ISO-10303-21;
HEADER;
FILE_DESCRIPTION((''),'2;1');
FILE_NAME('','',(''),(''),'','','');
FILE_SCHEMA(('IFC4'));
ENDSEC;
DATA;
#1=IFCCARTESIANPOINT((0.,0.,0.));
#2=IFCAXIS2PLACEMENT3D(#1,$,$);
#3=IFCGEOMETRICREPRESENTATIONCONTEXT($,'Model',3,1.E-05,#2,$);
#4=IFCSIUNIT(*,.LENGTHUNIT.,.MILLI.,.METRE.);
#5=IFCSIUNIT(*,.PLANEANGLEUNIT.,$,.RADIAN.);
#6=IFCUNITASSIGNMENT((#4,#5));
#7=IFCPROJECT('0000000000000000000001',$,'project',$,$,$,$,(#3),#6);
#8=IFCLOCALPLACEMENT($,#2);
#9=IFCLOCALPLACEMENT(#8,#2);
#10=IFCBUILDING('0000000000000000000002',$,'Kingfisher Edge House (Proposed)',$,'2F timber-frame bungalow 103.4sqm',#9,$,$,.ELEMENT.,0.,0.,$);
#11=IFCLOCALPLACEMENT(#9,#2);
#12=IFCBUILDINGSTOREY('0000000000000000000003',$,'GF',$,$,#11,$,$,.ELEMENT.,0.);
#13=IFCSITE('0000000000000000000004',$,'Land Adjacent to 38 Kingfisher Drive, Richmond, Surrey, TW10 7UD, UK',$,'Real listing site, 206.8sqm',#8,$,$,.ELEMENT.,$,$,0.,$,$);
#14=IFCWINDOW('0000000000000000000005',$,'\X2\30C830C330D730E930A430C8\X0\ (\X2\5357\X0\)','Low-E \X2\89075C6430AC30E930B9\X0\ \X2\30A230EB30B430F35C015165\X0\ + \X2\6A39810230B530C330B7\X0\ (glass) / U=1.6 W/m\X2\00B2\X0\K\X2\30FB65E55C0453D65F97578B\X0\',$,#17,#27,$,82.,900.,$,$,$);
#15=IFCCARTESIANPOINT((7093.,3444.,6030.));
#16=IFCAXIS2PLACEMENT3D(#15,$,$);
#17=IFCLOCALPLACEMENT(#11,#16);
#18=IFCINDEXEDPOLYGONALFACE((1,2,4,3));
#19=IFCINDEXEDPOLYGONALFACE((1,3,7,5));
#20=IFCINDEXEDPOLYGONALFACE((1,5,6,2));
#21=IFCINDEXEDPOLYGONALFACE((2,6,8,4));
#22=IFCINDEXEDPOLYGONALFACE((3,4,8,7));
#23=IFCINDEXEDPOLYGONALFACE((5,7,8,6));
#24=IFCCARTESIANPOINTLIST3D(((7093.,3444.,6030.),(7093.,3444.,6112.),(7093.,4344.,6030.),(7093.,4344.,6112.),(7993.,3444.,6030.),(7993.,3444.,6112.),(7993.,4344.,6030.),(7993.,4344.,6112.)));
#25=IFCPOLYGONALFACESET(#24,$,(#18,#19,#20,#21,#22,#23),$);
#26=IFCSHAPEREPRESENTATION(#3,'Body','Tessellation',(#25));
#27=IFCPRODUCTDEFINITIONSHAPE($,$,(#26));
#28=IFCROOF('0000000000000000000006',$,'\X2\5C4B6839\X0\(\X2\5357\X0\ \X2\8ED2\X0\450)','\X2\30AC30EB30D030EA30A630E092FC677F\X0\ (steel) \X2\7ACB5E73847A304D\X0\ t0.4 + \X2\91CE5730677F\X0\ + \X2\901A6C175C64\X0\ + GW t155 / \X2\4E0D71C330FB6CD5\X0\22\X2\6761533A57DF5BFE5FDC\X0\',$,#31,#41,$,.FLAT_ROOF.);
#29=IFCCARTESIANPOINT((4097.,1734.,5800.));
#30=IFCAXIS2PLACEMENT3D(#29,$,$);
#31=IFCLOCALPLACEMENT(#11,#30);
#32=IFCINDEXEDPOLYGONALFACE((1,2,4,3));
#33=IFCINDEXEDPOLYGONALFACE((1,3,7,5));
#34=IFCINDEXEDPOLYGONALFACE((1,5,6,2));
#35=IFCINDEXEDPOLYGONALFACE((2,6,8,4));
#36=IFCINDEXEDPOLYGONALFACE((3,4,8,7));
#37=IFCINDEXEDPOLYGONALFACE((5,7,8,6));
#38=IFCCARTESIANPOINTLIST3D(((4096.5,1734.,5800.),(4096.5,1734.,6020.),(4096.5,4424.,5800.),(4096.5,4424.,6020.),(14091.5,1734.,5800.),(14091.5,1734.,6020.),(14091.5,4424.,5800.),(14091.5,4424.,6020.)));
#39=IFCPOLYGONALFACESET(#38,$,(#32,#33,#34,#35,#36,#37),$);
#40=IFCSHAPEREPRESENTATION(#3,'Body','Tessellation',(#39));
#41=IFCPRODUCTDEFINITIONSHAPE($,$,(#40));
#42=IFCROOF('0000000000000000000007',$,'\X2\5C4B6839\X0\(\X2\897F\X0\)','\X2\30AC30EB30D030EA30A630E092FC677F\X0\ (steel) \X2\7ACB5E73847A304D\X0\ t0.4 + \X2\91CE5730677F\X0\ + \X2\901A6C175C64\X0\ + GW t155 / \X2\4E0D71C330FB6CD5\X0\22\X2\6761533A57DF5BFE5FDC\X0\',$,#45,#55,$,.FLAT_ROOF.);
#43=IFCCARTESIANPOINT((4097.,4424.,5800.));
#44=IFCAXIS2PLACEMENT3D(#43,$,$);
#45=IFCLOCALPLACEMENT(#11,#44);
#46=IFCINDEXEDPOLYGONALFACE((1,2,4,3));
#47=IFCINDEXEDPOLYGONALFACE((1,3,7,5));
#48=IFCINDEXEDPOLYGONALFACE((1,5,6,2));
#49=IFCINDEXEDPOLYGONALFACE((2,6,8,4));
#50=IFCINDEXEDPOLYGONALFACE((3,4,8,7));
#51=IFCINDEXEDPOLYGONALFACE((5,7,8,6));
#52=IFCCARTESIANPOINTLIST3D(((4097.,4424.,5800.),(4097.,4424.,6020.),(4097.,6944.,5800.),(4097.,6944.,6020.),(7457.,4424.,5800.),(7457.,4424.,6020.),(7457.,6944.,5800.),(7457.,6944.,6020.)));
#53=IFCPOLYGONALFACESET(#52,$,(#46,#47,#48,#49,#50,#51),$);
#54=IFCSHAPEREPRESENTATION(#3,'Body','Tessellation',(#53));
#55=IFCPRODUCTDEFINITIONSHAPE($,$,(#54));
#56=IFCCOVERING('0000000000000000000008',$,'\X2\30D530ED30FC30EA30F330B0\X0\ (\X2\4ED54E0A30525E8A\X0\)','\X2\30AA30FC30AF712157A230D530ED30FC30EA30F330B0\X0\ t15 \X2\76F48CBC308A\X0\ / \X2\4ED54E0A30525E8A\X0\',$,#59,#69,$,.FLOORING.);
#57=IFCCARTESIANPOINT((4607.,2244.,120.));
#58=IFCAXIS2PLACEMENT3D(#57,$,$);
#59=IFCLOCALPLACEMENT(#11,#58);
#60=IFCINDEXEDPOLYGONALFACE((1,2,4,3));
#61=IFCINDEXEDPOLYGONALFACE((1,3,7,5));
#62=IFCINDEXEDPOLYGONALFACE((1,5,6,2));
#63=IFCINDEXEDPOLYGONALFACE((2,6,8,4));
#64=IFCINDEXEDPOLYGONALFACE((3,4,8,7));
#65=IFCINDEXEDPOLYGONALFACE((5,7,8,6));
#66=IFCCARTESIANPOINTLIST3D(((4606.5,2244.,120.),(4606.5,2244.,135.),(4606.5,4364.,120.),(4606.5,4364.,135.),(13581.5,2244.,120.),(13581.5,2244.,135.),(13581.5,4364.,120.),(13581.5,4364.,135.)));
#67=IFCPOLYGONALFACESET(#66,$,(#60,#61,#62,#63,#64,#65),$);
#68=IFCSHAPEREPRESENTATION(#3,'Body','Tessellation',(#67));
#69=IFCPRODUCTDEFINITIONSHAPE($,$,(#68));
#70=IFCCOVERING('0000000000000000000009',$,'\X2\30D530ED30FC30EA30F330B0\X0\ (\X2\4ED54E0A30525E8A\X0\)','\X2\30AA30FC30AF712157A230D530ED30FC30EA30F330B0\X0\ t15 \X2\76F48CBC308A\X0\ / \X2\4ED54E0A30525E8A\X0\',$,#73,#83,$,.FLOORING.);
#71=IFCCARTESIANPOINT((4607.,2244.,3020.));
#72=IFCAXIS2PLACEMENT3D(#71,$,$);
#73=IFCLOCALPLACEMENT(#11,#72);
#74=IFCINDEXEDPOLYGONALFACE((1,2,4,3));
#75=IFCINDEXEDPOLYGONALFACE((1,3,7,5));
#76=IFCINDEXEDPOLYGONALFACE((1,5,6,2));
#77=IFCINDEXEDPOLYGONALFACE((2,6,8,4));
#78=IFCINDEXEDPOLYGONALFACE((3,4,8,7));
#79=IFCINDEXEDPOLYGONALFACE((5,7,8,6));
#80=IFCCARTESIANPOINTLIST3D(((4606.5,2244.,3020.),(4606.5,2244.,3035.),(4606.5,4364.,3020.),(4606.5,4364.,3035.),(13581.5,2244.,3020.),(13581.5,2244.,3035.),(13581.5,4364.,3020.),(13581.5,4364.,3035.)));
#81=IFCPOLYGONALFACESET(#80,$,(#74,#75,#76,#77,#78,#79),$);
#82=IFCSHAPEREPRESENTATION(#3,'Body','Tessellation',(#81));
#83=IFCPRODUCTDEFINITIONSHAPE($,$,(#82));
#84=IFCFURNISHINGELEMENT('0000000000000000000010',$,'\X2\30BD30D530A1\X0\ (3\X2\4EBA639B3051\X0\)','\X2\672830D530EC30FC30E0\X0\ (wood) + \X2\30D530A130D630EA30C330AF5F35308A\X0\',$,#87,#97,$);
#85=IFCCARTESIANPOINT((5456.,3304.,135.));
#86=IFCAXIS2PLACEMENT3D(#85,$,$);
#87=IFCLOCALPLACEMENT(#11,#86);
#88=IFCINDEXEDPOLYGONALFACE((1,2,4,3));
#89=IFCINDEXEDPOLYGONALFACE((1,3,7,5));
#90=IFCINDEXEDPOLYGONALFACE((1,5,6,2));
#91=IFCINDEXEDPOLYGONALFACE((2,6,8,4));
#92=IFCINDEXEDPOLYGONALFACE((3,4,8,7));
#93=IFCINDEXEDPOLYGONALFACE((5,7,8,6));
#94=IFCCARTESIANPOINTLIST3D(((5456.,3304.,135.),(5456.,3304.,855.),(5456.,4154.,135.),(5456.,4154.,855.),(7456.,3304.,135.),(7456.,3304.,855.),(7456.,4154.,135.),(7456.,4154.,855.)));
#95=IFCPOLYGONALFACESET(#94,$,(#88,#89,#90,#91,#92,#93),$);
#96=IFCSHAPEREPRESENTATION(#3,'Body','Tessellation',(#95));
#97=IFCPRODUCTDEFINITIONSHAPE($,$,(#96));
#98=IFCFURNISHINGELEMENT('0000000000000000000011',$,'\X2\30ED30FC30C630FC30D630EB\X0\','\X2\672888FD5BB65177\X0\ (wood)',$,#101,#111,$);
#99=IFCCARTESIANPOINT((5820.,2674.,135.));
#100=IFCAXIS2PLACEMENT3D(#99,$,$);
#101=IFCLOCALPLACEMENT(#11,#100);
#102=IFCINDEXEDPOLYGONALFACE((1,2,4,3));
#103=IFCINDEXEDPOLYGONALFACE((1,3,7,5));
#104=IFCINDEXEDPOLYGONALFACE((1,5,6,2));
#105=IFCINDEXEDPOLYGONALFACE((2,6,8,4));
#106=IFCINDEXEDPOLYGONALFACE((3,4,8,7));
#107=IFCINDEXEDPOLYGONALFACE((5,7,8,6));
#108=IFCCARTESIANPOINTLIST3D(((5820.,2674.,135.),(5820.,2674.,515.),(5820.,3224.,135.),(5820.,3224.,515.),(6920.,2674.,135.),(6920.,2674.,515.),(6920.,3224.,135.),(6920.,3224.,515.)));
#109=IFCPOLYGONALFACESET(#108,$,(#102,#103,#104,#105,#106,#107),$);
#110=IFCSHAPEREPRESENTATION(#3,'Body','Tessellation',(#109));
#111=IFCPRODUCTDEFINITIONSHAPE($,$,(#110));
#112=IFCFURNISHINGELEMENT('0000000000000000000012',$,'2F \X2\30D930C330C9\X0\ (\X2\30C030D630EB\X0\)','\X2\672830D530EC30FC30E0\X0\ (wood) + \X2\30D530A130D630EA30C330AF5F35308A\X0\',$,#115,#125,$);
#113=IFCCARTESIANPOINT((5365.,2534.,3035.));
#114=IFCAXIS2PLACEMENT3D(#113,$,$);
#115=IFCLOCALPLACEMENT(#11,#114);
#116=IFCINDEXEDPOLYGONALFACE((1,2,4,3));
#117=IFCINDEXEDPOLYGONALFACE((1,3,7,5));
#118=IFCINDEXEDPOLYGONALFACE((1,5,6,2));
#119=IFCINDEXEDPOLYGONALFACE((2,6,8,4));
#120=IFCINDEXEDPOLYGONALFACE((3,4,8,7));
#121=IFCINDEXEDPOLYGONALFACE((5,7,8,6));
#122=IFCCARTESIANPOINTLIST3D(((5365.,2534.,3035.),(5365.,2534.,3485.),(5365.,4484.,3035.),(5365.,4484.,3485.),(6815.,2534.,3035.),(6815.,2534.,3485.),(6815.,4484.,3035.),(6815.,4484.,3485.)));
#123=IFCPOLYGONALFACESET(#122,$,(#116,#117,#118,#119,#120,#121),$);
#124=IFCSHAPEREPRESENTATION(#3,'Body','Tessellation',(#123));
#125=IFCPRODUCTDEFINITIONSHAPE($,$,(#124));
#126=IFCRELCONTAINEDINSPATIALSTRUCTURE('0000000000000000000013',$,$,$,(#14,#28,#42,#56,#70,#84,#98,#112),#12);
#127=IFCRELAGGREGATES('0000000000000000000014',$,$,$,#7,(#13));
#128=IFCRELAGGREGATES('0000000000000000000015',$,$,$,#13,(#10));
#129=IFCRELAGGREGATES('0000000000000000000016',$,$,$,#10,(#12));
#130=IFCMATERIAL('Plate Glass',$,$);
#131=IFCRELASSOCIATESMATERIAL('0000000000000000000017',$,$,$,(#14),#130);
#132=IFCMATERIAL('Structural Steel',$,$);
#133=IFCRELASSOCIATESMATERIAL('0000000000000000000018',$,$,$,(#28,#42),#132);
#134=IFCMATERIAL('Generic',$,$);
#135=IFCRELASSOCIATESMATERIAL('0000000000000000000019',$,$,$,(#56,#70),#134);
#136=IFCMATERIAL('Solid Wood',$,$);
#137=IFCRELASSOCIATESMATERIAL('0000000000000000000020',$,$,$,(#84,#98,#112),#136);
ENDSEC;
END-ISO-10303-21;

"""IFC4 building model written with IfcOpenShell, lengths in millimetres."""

from ifc_helpers import new_model, si_unit, frame, frame_2d, origin, place, context, project, spatial, rectangle, extrude, material, element, save


model = new_model("IFC4")

# Units and contexts
model_context = context("Model", 3, precision=1e-05, world=origin())
ifc_project = project(units=[si_unit("LENGTHUNIT", "METRE", prefix="MILLI"), si_unit("PLANEANGLEUNIT", "RADIAN")], contexts=[model_context])

# Site, building, storey
site_placement = place(None, origin())
site = spatial("IfcSite", under=ifc_project, at=site_placement, Name="Land Adjacent to 38 Kingfisher Drive, Richmond, Surrey, TW10 7UD, UK", ObjectType="Real listing site, 206.8sqm", CompositionType="ELEMENT", RefElevation=0.0)
building_placement = place(site_placement, origin())
building = spatial("IfcBuilding", under=site, at=building_placement, Name="Kingfisher Edge House (Proposed)", ObjectType="2F timber-frame bungalow 103.4sqm", CompositionType="ELEMENT", ElevationOfRefHeight=0.0, ElevationOfTerrain=0.0)
storey_placement = place(building_placement, origin())
storey = spatial("IfcBuildingStorey", under=building, at=storey_placement, Name="GF", CompositionType="ELEMENT", Elevation=0.0)

# Shared definitions
ifc_material_1 = material(Name="Solid Wood")

# Shared definitions
ifc_material_2 = material(Name="Plate Glass")

# Window
window_1_placement = place(storey_placement, frame((7093.0, 3444.0, 6030.0)))
element("IfcWindow", 1, at=window_1_placement, inside=storey, material=ifc_material_2, Name="トップライト (南)", Description="Low-E 複層ガラス アルゴン封入 + 樹脂サッシ (glass) / U=1.6 W/m²K・日射取得型", OverallHeight=82.0, OverallWidth=900.0, context=model_context, shape_type="SweptSolid", body=[
    extrude(rectangle(XDim=900.0, YDim=900.0, at=frame_2d((450.0, 450.0))), frame((7093.0, 3444.0, 6030.0)), (0.0, 0.0, 1.0), 82.0),
])

# Roofs
ifc_material_3 = material(Name="Structural Steel")
roof_1_placement = place(storey_placement, frame((4097.0, 1734.0, 5800.0)))
element("IfcRoof", 2, at=roof_1_placement, inside=storey, material=ifc_material_3, Name="屋根(南 軒450)", Description="ガルバリウム鋼板 (steel) 立平葺き t0.4 + 野地板 + 通気層 + GW t155 / 不燃・法22条区域対応", PredefinedType="FLAT_ROOF", context=model_context, shape_type="SweptSolid", body=[
    extrude(rectangle(XDim=9995.0, YDim=2690.0, at=frame_2d((4997.0, 1345.0))), frame((4097.0, 1734.0, 5800.0)), (0.0, 0.0, 1.0), 220.0),
])
roof_2_placement = place(storey_placement, frame((4097.0, 4424.0, 5800.0)))
element("IfcRoof", 3, at=roof_2_placement, inside=storey, material=ifc_material_3, Name="屋根(西)", Description="ガルバリウム鋼板 (steel) 立平葺き t0.4 + 野地板 + 通気層 + GW t155 / 不燃・法22条区域対応", PredefinedType="FLAT_ROOF", context=model_context, shape_type="SweptSolid", body=[
    extrude(rectangle(XDim=3360.0, YDim=2520.0, at=frame_2d((1680.0, 1260.0))), frame((4097.0, 4424.0, 5800.0)), (0.0, 0.0, 1.0), 220.0),
])

# Coverings
ifc_material_4 = material(Name="Generic")
covering_1_placement = place(storey_placement, frame((4607.0, 2244.0, 120.0)))
element("IfcCovering", 4, at=covering_1_placement, inside=storey, material=ifc_material_4, Name="フローリング (仕上げ床)", Description="オーク無垢フローリング t15 直貼り / 仕上げ床", PredefinedType="FLOORING", context=model_context, shape_type="SweptSolid", body=[
    extrude(rectangle(XDim=8975.0, YDim=2120.0, at=frame_2d((4487.0, 1060.0))), frame((4607.0, 2244.0, 120.0)), (0.0, 0.0, 1.0), 15.0),
])
covering_2_placement = place(storey_placement, frame((4607.0, 2244.0, 3020.0)))
element("IfcCovering", 5, at=covering_2_placement, inside=storey, material=ifc_material_4, Name="フローリング (仕上げ床)", Description="オーク無垢フローリング t15 直貼り / 仕上げ床", PredefinedType="FLOORING", context=model_context, shape_type="SweptSolid", body=[
    extrude(rectangle(XDim=8975.0, YDim=2120.0, at=frame_2d((4487.0, 1060.0))), frame((4607.0, 2244.0, 3020.0)), (0.0, 0.0, 1.0), 15.0),
])

# Furnishing elements
furnishing_1_placement = place(storey_placement, frame((5456.0, 3304.0, 135.0)))
element("IfcFurnishingElement", 6, at=furnishing_1_placement, inside=storey, material=ifc_material_1, Name="ソファ (3人掛け)", Description="木フレーム (wood) + ファブリック張り", context=model_context, shape_type="SweptSolid", body=[
    extrude(rectangle(XDim=2000.0, YDim=850.0, at=frame_2d((1000.0, 425.0))), frame((5456.0, 3304.0, 135.0)), (0.0, 0.0, 1.0), 720.0),
])
furnishing_2_placement = place(storey_placement, frame((5820.0, 2674.0, 135.0)))
element("IfcFurnishingElement", 7, at=furnishing_2_placement, inside=storey, material=ifc_material_1, Name="ローテーブル", Description="木製家具 (wood)", context=model_context, shape_type="SweptSolid", body=[
    extrude(rectangle(XDim=1100.0, YDim=550.0, at=frame_2d((550.0, 275.0))), frame((5820.0, 2674.0, 135.0)), (0.0, 0.0, 1.0), 380.0),
])
furnishing_3_placement = place(storey_placement, frame((5365.0, 2534.0, 3035.0)))
element("IfcFurnishingElement", 8, at=furnishing_3_placement, inside=storey, material=ifc_material_1, Name="2F ベッド (ダブル)", Description="木フレーム (wood) + ファブリック張り", context=model_context, shape_type="SweptSolid", body=[
    extrude(rectangle(XDim=1450.0, YDim=1950.0, at=frame_2d((725.0, 975.0))), frame((5365.0, 2534.0, 3035.0)), (0.0, 0.0, 1.0), 450.0),
])

save(model, "model.ifc")
